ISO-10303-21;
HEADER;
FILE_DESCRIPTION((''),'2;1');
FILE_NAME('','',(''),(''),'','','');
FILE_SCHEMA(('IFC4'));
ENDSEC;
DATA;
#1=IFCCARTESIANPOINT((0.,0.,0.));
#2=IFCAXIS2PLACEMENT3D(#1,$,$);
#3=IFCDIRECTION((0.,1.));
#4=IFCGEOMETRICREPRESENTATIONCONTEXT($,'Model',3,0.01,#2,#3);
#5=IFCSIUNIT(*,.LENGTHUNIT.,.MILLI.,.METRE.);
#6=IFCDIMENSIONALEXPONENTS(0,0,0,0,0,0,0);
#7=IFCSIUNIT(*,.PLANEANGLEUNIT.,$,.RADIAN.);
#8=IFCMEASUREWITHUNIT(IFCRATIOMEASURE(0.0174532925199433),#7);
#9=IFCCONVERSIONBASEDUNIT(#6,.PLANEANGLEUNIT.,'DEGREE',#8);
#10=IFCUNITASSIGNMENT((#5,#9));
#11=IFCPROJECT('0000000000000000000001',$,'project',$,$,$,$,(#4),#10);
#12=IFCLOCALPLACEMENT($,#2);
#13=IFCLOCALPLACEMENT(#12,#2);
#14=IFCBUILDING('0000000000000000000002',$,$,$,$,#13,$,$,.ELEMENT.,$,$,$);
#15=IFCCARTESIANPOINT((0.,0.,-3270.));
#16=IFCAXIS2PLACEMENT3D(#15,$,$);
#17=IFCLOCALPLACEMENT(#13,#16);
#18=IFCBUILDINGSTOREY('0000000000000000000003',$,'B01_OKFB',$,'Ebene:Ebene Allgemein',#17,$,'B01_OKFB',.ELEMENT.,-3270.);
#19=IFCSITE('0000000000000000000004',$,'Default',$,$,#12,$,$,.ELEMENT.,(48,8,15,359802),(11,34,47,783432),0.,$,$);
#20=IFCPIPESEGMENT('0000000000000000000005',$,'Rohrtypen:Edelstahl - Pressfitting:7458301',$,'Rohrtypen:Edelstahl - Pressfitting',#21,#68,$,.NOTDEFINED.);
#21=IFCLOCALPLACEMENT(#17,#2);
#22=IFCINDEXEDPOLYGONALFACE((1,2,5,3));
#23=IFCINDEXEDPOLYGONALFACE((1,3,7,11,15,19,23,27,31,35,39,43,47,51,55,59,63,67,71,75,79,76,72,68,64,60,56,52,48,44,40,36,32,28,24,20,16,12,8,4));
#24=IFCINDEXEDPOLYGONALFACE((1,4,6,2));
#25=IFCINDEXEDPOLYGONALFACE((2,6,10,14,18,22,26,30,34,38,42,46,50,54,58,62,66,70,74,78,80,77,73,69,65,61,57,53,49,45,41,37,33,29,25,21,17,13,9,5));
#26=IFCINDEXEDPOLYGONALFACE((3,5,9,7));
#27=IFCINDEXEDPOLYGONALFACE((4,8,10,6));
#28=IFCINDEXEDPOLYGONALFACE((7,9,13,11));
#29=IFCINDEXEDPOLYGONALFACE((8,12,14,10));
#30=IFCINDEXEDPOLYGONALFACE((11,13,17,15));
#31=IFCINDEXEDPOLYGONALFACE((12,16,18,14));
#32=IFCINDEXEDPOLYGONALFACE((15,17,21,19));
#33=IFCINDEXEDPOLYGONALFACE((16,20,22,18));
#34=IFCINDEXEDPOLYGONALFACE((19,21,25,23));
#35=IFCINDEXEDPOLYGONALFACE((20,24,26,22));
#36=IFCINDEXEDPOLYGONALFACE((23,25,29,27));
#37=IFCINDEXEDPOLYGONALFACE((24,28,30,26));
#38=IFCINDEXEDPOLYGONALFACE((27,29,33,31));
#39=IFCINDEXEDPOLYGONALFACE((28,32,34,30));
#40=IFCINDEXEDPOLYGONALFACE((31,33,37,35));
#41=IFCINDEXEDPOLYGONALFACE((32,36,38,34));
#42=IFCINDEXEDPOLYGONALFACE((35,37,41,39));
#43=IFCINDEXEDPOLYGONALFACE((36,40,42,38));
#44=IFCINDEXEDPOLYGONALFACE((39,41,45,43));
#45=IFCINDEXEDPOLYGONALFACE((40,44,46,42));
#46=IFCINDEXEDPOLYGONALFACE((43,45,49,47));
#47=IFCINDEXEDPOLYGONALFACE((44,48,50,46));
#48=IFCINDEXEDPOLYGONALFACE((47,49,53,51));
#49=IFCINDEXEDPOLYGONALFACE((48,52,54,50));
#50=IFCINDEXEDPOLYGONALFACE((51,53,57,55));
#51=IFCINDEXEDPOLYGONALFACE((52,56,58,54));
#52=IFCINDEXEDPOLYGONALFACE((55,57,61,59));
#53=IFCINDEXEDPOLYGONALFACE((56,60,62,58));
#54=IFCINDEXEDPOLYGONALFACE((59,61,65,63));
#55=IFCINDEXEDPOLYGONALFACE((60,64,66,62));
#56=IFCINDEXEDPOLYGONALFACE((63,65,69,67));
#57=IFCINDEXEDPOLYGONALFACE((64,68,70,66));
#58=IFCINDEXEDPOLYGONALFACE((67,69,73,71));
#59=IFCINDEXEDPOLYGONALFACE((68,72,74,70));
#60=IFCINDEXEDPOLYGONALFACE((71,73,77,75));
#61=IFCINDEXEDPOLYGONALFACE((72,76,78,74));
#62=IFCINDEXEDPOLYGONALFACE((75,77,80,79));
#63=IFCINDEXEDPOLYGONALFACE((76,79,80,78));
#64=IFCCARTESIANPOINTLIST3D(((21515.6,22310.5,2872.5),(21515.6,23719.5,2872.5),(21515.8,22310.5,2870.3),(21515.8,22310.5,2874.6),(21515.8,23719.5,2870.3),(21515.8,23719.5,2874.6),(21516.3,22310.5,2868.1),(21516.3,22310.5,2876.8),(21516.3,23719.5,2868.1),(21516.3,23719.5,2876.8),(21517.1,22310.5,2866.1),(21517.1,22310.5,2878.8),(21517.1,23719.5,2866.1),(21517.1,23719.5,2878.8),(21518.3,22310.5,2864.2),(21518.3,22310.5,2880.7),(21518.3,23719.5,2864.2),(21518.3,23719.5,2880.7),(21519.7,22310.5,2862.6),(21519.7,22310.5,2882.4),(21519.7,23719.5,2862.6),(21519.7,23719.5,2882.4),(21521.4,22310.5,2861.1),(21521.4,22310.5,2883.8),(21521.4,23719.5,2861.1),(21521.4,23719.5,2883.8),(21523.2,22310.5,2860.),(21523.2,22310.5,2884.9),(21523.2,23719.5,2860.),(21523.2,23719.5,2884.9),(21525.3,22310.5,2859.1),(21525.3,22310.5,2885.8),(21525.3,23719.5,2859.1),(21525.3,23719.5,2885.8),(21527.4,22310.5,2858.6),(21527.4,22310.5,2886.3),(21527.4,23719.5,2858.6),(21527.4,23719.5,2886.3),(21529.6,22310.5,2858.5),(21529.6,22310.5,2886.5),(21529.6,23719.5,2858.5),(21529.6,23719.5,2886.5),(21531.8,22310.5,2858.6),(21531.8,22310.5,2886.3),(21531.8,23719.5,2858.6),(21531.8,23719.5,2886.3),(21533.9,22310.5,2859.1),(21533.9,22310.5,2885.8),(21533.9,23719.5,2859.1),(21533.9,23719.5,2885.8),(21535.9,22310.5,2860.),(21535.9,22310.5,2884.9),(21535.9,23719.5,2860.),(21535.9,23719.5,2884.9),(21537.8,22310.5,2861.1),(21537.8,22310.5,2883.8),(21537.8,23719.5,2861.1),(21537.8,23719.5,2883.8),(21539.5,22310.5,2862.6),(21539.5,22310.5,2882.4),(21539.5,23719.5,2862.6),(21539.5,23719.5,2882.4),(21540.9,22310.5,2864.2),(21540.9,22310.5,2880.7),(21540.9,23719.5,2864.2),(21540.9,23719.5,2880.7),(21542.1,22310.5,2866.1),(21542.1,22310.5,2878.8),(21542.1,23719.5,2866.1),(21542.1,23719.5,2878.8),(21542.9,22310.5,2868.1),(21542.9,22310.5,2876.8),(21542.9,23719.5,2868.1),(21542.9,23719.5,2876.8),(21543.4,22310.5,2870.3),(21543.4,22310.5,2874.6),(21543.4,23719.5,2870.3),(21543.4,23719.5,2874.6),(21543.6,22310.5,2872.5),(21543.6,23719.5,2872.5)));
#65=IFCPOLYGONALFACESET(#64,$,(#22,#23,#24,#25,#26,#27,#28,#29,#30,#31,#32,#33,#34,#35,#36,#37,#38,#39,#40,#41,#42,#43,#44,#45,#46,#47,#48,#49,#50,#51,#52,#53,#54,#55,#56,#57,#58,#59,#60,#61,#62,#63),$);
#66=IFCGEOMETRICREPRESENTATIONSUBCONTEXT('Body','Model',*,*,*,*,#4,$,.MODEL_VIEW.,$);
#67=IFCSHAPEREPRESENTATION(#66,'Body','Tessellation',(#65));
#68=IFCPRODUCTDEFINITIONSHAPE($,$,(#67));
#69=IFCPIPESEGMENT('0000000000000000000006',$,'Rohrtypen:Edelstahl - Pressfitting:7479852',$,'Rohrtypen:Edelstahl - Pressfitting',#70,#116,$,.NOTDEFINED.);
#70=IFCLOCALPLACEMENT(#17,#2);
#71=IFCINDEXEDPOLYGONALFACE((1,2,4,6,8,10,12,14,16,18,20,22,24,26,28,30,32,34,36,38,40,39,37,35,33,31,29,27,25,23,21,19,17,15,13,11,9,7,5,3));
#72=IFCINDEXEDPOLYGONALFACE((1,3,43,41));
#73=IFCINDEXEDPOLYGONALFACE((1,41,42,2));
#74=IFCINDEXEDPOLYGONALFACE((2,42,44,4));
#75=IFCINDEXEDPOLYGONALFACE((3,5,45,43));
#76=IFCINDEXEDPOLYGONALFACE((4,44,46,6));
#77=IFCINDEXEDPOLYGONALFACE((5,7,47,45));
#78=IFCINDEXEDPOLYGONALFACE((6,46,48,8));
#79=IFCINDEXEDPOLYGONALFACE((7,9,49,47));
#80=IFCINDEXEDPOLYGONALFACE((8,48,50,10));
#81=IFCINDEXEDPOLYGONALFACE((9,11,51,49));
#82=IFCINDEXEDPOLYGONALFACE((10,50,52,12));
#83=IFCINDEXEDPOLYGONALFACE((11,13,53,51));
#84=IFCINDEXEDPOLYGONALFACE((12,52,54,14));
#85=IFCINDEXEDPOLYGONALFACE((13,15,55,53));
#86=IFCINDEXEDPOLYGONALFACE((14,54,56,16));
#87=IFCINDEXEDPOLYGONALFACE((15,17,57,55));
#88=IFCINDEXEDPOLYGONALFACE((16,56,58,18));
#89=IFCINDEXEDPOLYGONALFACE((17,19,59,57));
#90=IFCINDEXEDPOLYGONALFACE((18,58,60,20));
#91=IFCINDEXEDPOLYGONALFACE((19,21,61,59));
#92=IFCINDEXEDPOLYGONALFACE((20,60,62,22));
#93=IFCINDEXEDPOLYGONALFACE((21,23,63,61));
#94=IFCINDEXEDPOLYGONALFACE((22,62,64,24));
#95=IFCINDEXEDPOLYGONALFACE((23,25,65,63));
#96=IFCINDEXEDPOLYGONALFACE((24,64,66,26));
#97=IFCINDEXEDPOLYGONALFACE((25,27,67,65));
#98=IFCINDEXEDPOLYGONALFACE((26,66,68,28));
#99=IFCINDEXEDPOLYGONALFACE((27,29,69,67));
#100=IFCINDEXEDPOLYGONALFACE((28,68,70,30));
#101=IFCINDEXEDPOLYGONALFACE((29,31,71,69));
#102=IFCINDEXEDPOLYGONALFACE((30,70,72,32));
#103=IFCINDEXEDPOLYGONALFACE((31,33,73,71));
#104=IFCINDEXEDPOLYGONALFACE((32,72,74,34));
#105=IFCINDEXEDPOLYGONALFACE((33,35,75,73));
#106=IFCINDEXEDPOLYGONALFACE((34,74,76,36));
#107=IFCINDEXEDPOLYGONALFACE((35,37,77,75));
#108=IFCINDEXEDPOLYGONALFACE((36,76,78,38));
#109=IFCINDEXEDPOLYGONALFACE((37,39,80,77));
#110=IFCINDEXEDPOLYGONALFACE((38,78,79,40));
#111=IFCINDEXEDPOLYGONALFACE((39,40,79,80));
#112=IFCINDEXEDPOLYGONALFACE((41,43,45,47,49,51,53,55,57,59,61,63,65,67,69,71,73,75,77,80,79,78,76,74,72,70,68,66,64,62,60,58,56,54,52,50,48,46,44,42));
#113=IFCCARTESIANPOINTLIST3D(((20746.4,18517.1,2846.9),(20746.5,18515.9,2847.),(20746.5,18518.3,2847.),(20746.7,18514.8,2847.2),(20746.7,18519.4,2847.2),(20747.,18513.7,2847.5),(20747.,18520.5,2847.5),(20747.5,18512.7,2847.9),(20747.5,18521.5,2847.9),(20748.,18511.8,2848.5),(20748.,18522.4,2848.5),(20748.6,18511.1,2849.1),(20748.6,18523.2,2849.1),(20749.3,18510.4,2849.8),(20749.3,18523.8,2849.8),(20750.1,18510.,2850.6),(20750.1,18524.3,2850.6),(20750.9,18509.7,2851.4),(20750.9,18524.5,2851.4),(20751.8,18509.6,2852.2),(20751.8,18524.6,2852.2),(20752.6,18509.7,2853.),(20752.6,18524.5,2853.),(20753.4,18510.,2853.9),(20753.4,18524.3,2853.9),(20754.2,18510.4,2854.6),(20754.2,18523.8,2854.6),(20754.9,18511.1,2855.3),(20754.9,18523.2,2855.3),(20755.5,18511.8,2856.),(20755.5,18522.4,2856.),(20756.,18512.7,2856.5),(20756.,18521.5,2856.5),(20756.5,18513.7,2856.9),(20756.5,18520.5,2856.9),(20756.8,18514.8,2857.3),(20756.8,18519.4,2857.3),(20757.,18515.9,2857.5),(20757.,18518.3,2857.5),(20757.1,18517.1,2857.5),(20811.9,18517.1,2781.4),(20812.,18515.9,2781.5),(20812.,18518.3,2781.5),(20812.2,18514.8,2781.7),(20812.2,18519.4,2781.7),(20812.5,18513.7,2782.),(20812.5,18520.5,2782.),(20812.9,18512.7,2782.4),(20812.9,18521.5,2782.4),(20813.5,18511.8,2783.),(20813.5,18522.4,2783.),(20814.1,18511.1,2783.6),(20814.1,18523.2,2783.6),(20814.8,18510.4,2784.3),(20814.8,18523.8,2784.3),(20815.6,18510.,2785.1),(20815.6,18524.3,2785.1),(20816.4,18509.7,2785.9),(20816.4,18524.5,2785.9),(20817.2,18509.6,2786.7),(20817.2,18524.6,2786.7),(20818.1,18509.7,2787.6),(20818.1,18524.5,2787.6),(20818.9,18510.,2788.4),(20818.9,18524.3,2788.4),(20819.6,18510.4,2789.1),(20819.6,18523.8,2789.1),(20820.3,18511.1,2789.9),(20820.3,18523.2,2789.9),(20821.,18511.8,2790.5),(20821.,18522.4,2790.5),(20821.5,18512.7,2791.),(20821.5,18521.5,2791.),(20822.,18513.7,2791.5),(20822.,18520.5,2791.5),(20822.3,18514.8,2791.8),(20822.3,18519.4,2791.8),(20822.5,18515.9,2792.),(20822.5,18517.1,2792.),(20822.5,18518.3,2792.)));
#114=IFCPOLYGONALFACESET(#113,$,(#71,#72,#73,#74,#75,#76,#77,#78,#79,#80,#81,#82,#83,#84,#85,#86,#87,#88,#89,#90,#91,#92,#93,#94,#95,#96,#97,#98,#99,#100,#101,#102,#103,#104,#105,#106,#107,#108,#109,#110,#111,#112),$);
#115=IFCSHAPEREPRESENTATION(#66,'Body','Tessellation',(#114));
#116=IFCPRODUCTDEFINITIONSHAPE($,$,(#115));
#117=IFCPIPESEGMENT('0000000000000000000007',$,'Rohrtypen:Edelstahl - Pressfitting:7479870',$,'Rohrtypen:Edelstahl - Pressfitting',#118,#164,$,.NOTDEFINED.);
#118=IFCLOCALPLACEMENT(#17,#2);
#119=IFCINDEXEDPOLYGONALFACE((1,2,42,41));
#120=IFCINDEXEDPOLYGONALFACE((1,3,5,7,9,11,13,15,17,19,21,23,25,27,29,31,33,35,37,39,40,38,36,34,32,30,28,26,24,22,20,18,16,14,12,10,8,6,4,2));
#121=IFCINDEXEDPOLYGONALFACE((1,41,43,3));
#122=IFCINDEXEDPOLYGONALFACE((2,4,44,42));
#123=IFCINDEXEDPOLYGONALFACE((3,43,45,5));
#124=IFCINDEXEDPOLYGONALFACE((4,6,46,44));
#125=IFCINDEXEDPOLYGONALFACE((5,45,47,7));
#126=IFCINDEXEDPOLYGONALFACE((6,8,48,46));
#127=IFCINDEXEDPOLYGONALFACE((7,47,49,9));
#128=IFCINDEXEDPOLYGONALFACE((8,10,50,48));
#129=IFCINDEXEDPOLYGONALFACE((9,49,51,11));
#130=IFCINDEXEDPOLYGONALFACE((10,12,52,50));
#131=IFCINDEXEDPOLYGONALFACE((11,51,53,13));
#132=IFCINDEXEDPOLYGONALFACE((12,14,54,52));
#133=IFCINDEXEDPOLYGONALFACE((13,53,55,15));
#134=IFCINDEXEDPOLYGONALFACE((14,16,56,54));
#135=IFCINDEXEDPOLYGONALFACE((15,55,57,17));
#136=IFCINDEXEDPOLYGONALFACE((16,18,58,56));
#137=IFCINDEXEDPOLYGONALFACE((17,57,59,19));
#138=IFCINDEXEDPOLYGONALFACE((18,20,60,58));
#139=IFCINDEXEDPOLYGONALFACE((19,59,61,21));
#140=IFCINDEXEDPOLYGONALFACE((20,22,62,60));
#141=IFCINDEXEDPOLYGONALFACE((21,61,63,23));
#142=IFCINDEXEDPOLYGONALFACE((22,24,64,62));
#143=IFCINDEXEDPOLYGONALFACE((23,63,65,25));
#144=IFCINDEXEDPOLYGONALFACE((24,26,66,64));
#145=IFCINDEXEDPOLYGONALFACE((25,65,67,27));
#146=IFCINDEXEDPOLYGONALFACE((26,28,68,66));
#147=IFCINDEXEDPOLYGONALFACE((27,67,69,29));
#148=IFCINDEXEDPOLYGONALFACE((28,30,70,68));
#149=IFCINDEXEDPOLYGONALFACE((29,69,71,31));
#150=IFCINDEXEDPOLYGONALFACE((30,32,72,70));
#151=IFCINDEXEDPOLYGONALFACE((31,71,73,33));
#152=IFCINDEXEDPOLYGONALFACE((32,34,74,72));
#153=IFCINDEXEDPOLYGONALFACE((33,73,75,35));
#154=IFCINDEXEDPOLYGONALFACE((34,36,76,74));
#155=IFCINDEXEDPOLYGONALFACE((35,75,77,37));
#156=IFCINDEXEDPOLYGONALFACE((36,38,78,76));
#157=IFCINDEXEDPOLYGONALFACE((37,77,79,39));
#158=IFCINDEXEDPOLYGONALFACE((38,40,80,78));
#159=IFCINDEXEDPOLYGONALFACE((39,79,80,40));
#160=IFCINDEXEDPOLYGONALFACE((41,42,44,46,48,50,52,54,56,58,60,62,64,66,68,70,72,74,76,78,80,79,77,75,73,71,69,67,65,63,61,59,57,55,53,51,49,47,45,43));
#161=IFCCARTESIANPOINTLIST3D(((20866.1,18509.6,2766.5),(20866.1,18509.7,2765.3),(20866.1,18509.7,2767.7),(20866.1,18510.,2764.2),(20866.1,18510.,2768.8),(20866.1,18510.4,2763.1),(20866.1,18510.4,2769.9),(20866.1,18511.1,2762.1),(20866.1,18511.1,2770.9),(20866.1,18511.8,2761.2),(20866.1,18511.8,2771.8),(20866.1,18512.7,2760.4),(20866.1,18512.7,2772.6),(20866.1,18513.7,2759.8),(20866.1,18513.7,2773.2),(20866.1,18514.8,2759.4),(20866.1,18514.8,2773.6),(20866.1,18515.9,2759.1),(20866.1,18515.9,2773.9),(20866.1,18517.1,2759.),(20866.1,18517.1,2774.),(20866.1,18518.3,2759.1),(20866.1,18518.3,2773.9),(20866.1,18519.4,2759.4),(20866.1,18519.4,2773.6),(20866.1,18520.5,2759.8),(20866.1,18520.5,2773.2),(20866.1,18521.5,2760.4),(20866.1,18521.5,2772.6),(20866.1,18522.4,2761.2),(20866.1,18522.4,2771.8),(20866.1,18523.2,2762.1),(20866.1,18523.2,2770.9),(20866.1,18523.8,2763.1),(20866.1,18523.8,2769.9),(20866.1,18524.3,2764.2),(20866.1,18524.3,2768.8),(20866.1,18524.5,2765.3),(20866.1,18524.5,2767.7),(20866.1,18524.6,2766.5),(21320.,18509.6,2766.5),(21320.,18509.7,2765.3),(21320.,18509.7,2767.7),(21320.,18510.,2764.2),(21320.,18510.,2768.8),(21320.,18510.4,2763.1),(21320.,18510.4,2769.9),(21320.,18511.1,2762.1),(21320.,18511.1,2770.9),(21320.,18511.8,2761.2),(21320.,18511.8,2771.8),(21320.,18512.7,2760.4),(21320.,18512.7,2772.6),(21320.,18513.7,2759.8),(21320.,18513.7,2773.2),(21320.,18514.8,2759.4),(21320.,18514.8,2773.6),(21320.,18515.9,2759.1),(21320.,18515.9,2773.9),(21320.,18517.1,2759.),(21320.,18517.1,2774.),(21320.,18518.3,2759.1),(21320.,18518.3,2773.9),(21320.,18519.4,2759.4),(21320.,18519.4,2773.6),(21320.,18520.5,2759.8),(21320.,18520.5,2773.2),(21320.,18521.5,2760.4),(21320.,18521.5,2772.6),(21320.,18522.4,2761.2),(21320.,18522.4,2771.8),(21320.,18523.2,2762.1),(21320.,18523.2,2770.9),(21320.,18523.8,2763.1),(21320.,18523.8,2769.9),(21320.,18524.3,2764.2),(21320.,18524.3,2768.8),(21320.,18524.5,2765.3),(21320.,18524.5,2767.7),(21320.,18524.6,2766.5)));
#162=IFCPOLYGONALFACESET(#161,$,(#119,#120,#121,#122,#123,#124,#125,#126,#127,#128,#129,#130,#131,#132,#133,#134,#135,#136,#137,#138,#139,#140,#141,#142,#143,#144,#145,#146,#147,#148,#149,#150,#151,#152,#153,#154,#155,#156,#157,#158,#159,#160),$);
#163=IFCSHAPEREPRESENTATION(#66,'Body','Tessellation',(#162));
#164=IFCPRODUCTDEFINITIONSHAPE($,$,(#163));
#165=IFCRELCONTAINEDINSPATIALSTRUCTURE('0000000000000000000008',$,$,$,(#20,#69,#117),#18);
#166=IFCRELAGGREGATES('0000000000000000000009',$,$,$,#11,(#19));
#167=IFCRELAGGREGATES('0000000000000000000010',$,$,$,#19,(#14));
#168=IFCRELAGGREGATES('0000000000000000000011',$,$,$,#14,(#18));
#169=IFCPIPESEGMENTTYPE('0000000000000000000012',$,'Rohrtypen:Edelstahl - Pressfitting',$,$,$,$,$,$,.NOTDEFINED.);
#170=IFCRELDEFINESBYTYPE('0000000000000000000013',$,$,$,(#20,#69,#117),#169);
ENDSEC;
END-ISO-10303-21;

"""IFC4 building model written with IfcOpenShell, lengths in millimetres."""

from ifc_helpers import new_model, entity, si_unit, converted_unit, direction, frame, origin, place, context, subcontext, project, spatial, indexed_curve, outline, extrude, type_object, element, save


model = new_model("IFC4")

# Units and contexts
model_context = context("Model", 3, precision=0.01, world=origin(), true_north=direction((0.0, 1.0)))
body_context = subcontext(model_context, "Body", "Model", "MODEL_VIEW")
ifc_project = project(units=[si_unit("LENGTHUNIT", "METRE", prefix="MILLI"), converted_unit("PLANEANGLEUNIT", "DEGREE", entity("IfcRatioMeasure", 0.0174532925199433), si_unit("PLANEANGLEUNIT", "RADIAN"), dimensions=[0, 0, 0, 0, 0, 0, 0])], contexts=[model_context])

# Site, building, storey
site_placement = place(None, origin())
site = spatial("IfcSite", under=ifc_project, at=site_placement, Name="Default", CompositionType="ELEMENT", RefLatitude=(48, 8, 15, 359802), RefLongitude=(11, 34, 47, 783432), RefElevation=0.0)
building_placement = place(site_placement, origin())
building = spatial("IfcBuilding", under=site, at=building_placement, CompositionType="ELEMENT")
storey_placement = place(building_placement, frame((0.0, 0.0, -3270.0)))
storey = spatial("IfcBuildingStorey", under=building, at=storey_placement, Name="B01_OKFB", ObjectType="Ebene:Ebene Allgemein", LongName="B01_OKFB", CompositionType="ELEMENT", Elevation=-3270.0)

# Pipe segments
pipe_segment_type_1 = type_object("IfcPipeSegmentType", Name="Rohrtypen:Edelstahl - Pressfitting", PredefinedType="NOTDEFINED")
pipe_segment_1_placement = place(storey_placement, origin())
element("IfcPipeSegment", 1, at=pipe_segment_1_placement, inside=storey, type_object=pipe_segment_type_1, Name="Rohrtypen:Edelstahl - Pressfitting:7458301", ObjectType="Rohrtypen:Edelstahl - Pressfitting", PredefinedType="NOTDEFINED", context=body_context, shape_type="SweptSolid", body=[
    extrude(outline(indexed_curve([(14.0, 0.0), (13.8, 2.2), (13.3, 4.3), (12.5, 6.4), (11.3, 8.2), (9.9, 9.9), (8.2, 11.3), (6.4, 12.5), (4.3, 13.3), (2.2, 13.8), (0.0, 14.0), (-2.2, 13.8), (-4.3, 13.3), (-6.4, 12.5), (-8.2, 11.3), (-9.9, 9.9), (-11.3, 8.2), (-12.5, 6.4), (-13.3, 4.3), (-13.8, 2.2), (-14.0, 0.0), (-13.8, -2.2), (-13.3, -4.3), (-12.5, -6.4), (-11.3, -8.2), (-9.9, -9.9), (-8.2, -11.3), (-6.4, -12.5), (-4.3, -13.3), (-2.2, -13.8), (0.0, -14.0), (2.2, -13.8), (4.3, -13.3), (6.4, -12.5), (8.2, -11.3), (9.9, -9.9), (11.3, -8.2), (12.5, -6.4), (13.3, -4.3), (13.8, -2.2), (14.0, 0.0)], self_intersect=False)), frame((21529.6, 22310.5, 2872.5), z_axis=(0.0, 1.0, 0.0), x_axis=(1.0, 0.0, 0.0)), (0.0, 0.0, 1.0), 1409.0),
])
pipe_segment_2_placement = place(storey_placement, origin())
element("IfcPipeSegment", 2, at=pipe_segment_2_placement, inside=storey, type_object=pipe_segment_type_1, Name="Rohrtypen:Edelstahl - Pressfitting:7479852", ObjectType="Rohrtypen:Edelstahl - Pressfitting", PredefinedType="NOTDEFINED", context=body_context, shape_type="SweptSolid", body=[
    extrude(outline(indexed_curve([(7.5, 0.0), (7.4, 1.2), (7.1, 2.3), (6.7, 3.4), (6.1, 4.4), (5.3, 5.3), (4.4, 6.1), (3.4, 6.7), (2.3, 7.1), (1.2, 7.4), (0.0, 7.5), (-1.2, 7.4), (-2.3, 7.1), (-3.4, 6.7), (-4.4, 6.1), (-5.3, 5.3), (-6.1, 4.4), (-6.7, 3.4), (-7.1, 2.3), (-7.4, 1.2), (-7.5, 0.0), (-7.4, -1.2), (-7.1, -2.3), (-6.7, -3.4), (-6.1, -4.4), (-5.3, -5.3), (-4.4, -6.1), (-3.4, -6.7), (-2.3, -7.1), (-1.2, -7.4), (0.0, -7.5), (1.2, -7.4), (2.3, -7.1), (3.4, -6.7), (4.4, -6.1), (5.3, -5.3), (6.1, -4.4), (6.7, -3.4), (7.1, -2.3), (7.4, -1.2), (7.5, 0.0)], self_intersect=False)), frame((20751.8, 18517.1, 2852.2), z_axis=(0.707107, 0.0, -0.707107), x_axis=(0.0, -1.0, 0.0)), (0.0, 0.0, 1.0), 92.6),
])
pipe_segment_3_placement = place(storey_placement, origin())
element("IfcPipeSegment", 3, at=pipe_segment_3_placement, inside=storey, type_object=pipe_segment_type_1, Name="Rohrtypen:Edelstahl - Pressfitting:7479870", ObjectType="Rohrtypen:Edelstahl - Pressfitting", PredefinedType="NOTDEFINED", context=body_context, shape_type="SweptSolid", body=[
    extrude(outline(indexed_curve([(7.5, 0.0), (7.4, 1.2), (7.1, 2.3), (6.7, 3.4), (6.1, 4.4), (5.3, 5.3), (4.4, 6.1), (3.4, 6.7), (2.3, 7.1), (1.2, 7.4), (0.0, 7.5), (-1.2, 7.4), (-2.3, 7.1), (-3.4, 6.7), (-4.4, 6.1), (-5.3, 5.3), (-6.1, 4.4), (-6.7, 3.4), (-7.1, 2.3), (-7.4, 1.2), (-7.5, 0.0), (-7.4, -1.2), (-7.1, -2.3), (-6.7, -3.4), (-6.1, -4.4), (-5.3, -5.3), (-4.4, -6.1), (-3.4, -6.7), (-2.3, -7.1), (-1.2, -7.4), (0.0, -7.5), (1.2, -7.4), (2.3, -7.1), (3.4, -6.7), (4.4, -6.1), (5.3, -5.3), (6.1, -4.4), (6.7, -3.4), (7.1, -2.3), (7.4, -1.2), (7.5, 0.0)], self_intersect=False)), frame((20866.1, 18517.1, 2766.5), z_axis=(1.0, 0.0, 0.0), x_axis=(0.0, -1.0, 0.0)), (0.0, 0.0, 1.0), 453.9),
])

save(model, "model.ifc")
